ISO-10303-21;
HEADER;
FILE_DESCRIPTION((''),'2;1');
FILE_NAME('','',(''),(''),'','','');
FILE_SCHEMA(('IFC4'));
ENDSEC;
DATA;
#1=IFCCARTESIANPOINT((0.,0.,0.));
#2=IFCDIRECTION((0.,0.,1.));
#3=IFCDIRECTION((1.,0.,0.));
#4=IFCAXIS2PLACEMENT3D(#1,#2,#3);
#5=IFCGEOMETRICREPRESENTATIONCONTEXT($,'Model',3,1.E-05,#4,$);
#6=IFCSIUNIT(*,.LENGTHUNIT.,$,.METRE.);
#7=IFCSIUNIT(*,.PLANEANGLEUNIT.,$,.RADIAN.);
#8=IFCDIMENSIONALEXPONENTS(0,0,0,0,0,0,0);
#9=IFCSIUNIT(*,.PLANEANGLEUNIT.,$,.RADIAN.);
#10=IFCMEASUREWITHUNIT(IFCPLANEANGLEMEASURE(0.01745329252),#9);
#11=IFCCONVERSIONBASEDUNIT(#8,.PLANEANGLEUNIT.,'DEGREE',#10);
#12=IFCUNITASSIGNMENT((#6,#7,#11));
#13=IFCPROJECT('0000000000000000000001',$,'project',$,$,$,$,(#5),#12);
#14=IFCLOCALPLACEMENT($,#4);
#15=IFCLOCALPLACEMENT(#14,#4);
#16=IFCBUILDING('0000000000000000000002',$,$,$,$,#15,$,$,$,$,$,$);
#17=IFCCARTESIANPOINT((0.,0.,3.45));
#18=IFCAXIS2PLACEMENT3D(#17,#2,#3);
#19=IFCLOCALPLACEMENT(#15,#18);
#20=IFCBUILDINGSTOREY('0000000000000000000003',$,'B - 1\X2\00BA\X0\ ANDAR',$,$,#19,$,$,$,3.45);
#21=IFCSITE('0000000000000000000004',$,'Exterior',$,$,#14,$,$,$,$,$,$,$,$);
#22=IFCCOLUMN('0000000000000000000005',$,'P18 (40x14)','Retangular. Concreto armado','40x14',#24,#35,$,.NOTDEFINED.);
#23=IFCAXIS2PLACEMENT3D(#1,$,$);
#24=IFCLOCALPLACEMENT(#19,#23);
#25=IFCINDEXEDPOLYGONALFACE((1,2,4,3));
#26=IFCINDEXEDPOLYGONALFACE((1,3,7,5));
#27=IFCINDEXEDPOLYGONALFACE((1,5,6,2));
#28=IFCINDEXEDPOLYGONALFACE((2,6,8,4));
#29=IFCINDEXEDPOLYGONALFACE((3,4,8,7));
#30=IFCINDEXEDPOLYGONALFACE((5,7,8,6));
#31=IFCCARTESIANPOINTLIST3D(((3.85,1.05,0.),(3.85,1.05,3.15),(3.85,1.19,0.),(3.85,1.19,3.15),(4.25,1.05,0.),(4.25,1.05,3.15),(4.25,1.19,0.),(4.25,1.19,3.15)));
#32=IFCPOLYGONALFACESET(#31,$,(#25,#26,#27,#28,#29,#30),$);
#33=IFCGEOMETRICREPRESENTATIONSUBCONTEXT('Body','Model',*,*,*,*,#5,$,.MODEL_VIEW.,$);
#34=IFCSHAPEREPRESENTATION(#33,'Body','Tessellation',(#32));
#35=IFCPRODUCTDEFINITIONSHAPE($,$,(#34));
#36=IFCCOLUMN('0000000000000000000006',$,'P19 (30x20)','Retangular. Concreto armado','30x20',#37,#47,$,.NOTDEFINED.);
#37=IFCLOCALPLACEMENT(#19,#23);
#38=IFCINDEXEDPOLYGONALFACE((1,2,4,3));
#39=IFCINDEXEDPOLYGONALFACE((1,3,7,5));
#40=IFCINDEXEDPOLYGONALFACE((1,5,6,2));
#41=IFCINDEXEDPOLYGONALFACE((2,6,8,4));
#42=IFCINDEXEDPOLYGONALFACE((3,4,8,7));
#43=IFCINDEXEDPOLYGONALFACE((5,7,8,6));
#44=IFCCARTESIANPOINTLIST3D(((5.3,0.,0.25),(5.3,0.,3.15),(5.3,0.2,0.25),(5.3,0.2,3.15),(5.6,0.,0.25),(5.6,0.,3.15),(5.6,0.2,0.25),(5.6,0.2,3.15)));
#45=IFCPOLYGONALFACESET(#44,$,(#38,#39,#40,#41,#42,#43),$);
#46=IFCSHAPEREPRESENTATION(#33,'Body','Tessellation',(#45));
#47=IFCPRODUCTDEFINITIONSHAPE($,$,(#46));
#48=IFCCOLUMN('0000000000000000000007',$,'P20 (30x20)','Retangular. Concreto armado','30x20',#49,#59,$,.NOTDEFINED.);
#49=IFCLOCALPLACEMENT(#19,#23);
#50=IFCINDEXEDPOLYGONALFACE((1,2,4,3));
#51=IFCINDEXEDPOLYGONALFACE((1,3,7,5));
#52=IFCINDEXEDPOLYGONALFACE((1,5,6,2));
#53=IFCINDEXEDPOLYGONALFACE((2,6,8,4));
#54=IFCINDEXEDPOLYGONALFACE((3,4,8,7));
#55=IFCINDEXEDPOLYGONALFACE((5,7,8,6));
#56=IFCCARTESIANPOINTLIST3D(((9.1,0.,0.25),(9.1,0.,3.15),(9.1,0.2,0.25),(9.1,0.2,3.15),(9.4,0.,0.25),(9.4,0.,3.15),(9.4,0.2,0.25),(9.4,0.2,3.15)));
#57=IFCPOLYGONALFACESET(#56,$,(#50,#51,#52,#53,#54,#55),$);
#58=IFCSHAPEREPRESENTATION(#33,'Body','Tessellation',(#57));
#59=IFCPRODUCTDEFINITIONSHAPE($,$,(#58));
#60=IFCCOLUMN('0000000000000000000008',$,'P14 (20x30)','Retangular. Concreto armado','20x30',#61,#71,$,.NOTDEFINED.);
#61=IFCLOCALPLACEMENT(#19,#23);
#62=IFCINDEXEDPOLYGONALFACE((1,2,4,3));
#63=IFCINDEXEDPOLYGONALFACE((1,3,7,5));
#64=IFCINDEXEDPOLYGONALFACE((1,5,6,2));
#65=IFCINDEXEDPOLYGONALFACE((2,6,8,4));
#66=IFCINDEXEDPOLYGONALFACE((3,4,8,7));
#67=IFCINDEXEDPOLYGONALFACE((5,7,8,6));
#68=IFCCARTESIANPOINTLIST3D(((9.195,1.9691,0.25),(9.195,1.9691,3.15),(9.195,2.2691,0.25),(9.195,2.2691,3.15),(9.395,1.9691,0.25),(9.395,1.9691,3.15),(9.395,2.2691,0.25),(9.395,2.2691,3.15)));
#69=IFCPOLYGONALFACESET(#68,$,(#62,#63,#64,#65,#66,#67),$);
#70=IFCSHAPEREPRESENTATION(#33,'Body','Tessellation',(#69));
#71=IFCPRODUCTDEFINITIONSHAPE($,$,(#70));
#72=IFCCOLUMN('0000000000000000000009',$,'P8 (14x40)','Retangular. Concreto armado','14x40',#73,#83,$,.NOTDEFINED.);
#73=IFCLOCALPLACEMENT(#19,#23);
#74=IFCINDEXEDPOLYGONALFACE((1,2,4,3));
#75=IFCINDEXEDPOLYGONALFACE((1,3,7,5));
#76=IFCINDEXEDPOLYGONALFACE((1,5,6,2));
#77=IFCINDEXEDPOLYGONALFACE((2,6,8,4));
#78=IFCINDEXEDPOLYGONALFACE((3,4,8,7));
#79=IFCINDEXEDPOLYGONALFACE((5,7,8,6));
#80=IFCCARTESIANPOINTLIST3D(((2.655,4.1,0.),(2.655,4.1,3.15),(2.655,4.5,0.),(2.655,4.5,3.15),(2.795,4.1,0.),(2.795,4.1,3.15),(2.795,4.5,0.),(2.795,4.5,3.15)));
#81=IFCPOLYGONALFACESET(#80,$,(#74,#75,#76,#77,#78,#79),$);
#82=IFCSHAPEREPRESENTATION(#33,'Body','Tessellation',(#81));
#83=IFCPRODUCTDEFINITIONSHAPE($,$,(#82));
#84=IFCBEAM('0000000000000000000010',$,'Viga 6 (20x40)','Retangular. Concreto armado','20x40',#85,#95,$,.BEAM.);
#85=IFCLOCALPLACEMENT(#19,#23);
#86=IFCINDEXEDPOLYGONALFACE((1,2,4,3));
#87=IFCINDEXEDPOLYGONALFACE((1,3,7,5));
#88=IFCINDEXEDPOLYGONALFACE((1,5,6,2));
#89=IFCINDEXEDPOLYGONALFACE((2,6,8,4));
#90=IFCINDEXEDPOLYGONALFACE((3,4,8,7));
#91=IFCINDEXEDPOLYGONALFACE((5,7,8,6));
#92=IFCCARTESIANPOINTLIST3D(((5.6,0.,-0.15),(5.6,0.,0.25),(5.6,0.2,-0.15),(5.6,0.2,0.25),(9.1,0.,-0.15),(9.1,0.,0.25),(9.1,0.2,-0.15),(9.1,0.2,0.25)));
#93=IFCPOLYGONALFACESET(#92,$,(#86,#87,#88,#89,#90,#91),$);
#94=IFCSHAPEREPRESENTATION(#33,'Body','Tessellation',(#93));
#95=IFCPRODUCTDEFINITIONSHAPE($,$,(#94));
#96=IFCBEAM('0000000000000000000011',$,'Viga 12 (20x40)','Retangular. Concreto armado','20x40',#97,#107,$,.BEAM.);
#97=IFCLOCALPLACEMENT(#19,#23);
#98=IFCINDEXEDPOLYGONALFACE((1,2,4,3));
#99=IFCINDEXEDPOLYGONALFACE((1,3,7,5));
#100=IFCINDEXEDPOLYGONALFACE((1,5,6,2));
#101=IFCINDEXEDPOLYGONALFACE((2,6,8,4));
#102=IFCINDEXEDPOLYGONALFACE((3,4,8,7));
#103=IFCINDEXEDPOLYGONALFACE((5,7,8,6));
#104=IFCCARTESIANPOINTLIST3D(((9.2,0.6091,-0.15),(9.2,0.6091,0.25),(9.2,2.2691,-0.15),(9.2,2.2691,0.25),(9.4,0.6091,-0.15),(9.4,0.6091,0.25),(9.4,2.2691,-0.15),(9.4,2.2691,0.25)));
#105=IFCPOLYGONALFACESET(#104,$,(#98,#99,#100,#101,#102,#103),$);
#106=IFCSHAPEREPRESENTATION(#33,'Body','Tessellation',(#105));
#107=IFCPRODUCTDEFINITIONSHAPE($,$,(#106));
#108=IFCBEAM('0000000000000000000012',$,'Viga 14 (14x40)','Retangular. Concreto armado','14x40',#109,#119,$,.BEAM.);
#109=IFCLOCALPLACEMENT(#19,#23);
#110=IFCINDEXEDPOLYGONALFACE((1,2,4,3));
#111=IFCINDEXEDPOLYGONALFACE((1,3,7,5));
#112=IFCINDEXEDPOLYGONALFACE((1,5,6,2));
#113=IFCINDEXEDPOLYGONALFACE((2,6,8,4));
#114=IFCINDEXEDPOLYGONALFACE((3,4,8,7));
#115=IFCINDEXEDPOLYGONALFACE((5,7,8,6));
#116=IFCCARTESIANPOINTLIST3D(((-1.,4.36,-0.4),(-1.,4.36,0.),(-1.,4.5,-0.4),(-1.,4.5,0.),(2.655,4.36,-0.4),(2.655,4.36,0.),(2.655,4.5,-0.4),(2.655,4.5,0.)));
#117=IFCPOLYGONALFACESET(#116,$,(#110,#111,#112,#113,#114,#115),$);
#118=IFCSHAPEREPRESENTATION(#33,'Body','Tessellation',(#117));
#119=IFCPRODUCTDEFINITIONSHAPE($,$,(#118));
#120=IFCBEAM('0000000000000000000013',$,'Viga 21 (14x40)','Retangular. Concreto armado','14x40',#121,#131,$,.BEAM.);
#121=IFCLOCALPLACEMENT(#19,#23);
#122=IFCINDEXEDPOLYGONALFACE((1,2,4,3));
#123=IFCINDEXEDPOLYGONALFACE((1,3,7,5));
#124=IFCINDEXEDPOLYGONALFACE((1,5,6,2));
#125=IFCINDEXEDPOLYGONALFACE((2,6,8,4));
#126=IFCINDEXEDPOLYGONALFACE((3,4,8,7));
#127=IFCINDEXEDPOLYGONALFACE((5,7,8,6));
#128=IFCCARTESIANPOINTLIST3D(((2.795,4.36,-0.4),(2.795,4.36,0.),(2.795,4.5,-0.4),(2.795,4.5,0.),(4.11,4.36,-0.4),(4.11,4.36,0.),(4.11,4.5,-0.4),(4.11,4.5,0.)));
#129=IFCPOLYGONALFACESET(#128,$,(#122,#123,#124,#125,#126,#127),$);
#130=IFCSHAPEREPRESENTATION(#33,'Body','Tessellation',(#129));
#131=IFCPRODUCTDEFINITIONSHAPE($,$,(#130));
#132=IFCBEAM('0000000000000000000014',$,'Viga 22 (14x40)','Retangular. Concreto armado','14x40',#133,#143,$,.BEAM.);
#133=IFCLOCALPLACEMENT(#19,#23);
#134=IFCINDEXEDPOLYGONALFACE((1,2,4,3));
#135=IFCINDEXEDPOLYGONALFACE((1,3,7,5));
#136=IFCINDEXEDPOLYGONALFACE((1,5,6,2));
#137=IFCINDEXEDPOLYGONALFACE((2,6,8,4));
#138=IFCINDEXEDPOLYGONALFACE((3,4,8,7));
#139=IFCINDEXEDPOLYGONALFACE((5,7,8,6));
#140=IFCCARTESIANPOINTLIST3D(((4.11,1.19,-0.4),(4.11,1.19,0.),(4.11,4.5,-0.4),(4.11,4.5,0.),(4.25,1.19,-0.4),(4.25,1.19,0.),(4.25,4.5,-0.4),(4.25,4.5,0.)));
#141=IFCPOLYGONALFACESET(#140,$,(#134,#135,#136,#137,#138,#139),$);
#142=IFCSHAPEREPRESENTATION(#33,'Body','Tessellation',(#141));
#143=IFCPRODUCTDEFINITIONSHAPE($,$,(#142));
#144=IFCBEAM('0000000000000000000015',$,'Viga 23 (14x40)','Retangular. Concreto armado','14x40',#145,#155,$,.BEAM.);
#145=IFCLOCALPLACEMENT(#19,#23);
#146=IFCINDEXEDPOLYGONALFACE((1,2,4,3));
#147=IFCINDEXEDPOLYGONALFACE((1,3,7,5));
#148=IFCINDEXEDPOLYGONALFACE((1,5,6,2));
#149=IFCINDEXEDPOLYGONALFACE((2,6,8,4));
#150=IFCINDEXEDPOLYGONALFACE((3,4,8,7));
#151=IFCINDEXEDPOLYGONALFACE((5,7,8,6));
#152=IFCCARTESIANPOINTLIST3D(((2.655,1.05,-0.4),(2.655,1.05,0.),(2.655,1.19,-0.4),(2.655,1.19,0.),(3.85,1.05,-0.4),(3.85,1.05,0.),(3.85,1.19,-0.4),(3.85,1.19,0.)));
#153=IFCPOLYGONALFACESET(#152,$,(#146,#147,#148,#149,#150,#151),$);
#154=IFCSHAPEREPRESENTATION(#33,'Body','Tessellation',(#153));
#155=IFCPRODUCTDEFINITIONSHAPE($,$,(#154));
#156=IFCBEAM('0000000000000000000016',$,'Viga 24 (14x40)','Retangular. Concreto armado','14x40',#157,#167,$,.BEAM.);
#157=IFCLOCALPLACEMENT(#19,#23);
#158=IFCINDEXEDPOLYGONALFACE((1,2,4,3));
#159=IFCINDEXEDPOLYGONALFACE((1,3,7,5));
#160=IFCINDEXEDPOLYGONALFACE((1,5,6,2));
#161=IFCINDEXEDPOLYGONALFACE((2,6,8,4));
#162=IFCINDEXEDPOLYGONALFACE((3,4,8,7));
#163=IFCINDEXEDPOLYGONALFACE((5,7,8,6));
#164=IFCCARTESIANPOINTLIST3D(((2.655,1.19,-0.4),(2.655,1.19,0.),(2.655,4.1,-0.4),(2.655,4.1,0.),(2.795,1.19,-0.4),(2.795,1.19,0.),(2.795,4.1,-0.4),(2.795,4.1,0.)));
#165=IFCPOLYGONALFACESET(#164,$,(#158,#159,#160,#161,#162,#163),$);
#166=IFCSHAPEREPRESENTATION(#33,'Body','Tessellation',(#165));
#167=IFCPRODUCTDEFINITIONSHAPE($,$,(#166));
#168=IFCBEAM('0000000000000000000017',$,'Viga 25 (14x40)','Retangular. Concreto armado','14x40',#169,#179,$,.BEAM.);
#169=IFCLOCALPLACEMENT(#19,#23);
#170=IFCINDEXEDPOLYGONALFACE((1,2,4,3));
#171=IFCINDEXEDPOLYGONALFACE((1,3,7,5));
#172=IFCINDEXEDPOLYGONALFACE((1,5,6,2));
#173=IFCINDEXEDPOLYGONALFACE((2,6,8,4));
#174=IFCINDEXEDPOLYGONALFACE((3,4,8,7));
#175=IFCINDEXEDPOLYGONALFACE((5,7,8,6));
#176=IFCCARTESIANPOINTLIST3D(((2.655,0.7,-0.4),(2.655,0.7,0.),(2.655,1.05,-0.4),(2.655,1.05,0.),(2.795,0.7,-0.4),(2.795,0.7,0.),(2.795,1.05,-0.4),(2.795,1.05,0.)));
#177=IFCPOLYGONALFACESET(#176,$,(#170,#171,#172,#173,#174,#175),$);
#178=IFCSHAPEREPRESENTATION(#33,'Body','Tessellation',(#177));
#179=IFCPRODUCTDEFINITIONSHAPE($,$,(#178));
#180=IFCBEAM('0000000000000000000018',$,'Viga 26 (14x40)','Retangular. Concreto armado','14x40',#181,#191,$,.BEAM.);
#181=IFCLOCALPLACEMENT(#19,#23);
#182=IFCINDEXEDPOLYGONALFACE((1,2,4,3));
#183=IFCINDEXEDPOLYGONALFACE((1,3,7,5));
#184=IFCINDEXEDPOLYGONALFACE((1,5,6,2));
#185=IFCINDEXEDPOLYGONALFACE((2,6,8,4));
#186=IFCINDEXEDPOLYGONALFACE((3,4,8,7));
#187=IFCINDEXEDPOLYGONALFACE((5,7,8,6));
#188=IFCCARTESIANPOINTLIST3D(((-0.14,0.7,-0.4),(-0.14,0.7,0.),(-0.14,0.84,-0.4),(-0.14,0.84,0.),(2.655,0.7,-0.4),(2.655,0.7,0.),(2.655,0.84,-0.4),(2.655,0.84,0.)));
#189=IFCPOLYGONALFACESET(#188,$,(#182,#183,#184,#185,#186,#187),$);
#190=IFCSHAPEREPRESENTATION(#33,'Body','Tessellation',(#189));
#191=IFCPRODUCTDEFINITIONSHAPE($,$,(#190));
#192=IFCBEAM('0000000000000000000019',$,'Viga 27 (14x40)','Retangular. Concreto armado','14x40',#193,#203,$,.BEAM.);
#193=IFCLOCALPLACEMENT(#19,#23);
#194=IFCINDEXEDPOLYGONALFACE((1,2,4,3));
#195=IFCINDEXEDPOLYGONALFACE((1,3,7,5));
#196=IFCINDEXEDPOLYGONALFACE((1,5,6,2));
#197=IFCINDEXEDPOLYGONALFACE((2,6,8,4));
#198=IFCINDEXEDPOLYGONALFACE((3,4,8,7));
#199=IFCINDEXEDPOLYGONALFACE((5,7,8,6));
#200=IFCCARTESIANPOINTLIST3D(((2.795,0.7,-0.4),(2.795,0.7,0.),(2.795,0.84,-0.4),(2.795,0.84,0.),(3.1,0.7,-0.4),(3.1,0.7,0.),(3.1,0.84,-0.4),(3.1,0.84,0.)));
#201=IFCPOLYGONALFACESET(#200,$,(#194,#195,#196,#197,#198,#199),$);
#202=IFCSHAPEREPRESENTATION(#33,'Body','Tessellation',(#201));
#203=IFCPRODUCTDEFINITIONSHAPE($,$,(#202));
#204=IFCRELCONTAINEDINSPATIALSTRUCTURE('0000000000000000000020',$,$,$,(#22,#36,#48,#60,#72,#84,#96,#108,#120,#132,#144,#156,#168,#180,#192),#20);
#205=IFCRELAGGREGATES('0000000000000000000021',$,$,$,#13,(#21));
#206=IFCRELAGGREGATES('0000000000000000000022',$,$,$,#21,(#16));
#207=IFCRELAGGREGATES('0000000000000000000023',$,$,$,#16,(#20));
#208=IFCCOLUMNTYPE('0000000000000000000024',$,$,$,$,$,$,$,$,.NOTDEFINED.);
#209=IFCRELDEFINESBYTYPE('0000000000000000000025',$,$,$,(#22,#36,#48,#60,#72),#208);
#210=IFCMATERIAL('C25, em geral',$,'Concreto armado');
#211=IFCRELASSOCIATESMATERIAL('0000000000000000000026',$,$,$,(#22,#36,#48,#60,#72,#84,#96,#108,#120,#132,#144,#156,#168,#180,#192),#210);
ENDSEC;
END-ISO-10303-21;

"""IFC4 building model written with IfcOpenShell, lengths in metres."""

from ifc_helpers import new_model, entity, si_unit, converted_unit, frame, frame_2d, origin_with_axes, origin_2d_with_axis, place, context, subcontext, project, spatial, rectangle, extrude, material, type_object, element, save


model = new_model("IFC4")

# Units and contexts
model_context = context("Model", 3, precision=1e-05, world=origin_with_axes())
body_context = subcontext(model_context, "Body", "Model", "MODEL_VIEW")
ifc_project = project(units=[si_unit("LENGTHUNIT", "METRE"), si_unit("PLANEANGLEUNIT", "RADIAN"), converted_unit("PLANEANGLEUNIT", "DEGREE", entity("IfcPlaneAngleMeasure", 0.01745329252), si_unit("PLANEANGLEUNIT", "RADIAN"), dimensions=[0, 0, 0, 0, 0, 0, 0])], contexts=[model_context])

# Site, building, storey
site_placement = place(None, origin_with_axes())
site = spatial("IfcSite", under=ifc_project, at=site_placement, Name="Exterior")
building_placement = place(site_placement, origin_with_axes())
building = spatial("IfcBuilding", under=site, at=building_placement)
storey_placement = place(building_placement, frame((0.0, 0.0, 3.45), z_axis=(0.0, 0.0, 1.0), x_axis=(1.0, 0.0, 0.0)))
storey = spatial("IfcBuildingStorey", under=building, at=storey_placement, Name="B - 1º ANDAR", Elevation=3.45)

# Columns
ifc_material = material(Name="C25, em geral", Category="Concreto armado")
column_type = type_object("IfcColumnType", PredefinedType="NOTDEFINED")
column_1_placement = place(storey_placement, frame((4.25, 1.12, 0.0), z_axis=(0.0, 0.0, 1.0), x_axis=(1.0, 0.0, 0.0)))
element("IfcColumn", 1, at=column_1_placement, inside=storey, type_object=column_type, material=ifc_material, Name="P18 (40x14)", Description="Retangular. Concreto armado", ObjectType="40x14", PredefinedType="NOTDEFINED", context=body_context, shape_type="SweptSolid", body=[
    extrude(rectangle(XDim=0.4, YDim=0.14, at=frame_2d((-0.2, 0.0), x_axis=(1.0, 0.0))), origin_with_axes(), (0.0, 0.0, 1.0), 3.15),
])
for number, where, z_axis, x_axis, name in (
    (2, (5.45, 0.1, 0.25), (0.0, 0.0, 1.0), (1.0, 0.0, 0.0), "P19 (30x20)"),
    (3, (9.25, 0.1, 0.25), (0.0, 0.0, 1.0), (1.0, 0.0, 0.0), "P20 (30x20)"),
):
    element("IfcColumn", number, at=place(storey_placement, frame(where, z_axis=z_axis, x_axis=x_axis)), inside=storey, type_object=column_type, material=ifc_material, Name=name, Description="Retangular. Concreto armado", ObjectType="30x20", PredefinedType="NOTDEFINED", context=body_context, shape_type="SweptSolid", body=[
        extrude(rectangle(XDim=0.3, YDim=0.2, at=origin_2d_with_axis()), origin_with_axes(), (0.0, 0.0, 1.0), 2.9),
    ])
column_2_placement = place(storey_placement, frame((9.295, 2.1191, 0.25), z_axis=(0.0, 0.0, 1.0), x_axis=(1.0, 0.0, 0.0)))
element("IfcColumn", 4, at=column_2_placement, inside=storey, type_object=column_type, material=ifc_material, Name="P14 (20x30)", Description="Retangular. Concreto armado", ObjectType="20x30", PredefinedType="NOTDEFINED", context=body_context, shape_type="SweptSolid", body=[
    extrude(rectangle(XDim=0.2, YDim=0.3, at=origin_2d_with_axis()), origin_with_axes(), (0.0, 0.0, 1.0), 2.9),
])
column_3_placement = place(storey_placement, frame((2.725, 4.5, 0.0), z_axis=(0.0, 0.0, 1.0), x_axis=(1.0, 0.0, 0.0)))
element("IfcColumn", 5, at=column_3_placement, inside=storey, type_object=column_type, material=ifc_material, Name="P8 (14x40)", Description="Retangular. Concreto armado", ObjectType="14x40", PredefinedType="NOTDEFINED", context=body_context, shape_type="SweptSolid", body=[
    extrude(rectangle(XDim=0.14, YDim=0.4, at=frame_2d((0.0, -0.2), x_axis=(1.0, 0.0))), origin_with_axes(), (0.0, 0.0, 1.0), 3.15),
])

# Beams
beam_1_placement = place(storey_placement, frame((9.1, 0.1, 0.25), z_axis=(-1.0, 0.0, 0.0), x_axis=(0.0, -1.0, 0.0)))
element("IfcBeam", 6, at=beam_1_placement, inside=storey, material=ifc_material, Name="Viga 6 (20x40)", Description="Retangular. Concreto armado", ObjectType="20x40", PredefinedType="BEAM", context=body_context, shape_type="SweptSolid", body=[
    extrude(rectangle(XDim=0.2, YDim=0.4, at=frame_2d((0.0, -0.2), x_axis=(1.0, 0.0))), origin_with_axes(), (0.0, 0.0, 1.0), 3.5),
])
beam_2_placement = place(storey_placement, frame((9.3, 2.2691, 0.25), z_axis=(0.0, -1.0, 0.0), x_axis=(1.0, 0.0, 0.0)))
element("IfcBeam", 7, at=beam_2_placement, inside=storey, material=ifc_material, Name="Viga 12 (20x40)", Description="Retangular. Concreto armado", ObjectType="20x40", PredefinedType="BEAM", context=body_context, shape_type="SweptSolid", body=[
    extrude(rectangle(XDim=0.2, YDim=0.4, at=frame_2d((0.0, -0.2), x_axis=(1.0, 0.0))), origin_with_axes(), (0.0, 0.0, 1.0), 1.66),
])
beam_3_placement = place(storey_placement, frame((2.655, 4.43, 0.0), z_axis=(-1.0, 0.0, 0.0), x_axis=(0.0, -1.0, 0.0)))
element("IfcBeam", 8, at=beam_3_placement, inside=storey, material=ifc_material, Name="Viga 14 (14x40)", Description="Retangular. Concreto armado", ObjectType="14x40", PredefinedType="BEAM", context=body_context, shape_type="SweptSolid", body=[
    extrude(rectangle(XDim=0.14, YDim=0.4, at=frame_2d((0.0, -0.2), x_axis=(1.0, 0.0))), origin_with_axes(), (0.0, 0.0, 1.0), 3.655),
])
beam_4_placement = place(storey_placement, frame((2.795, 4.43, 0.0), z_axis=(1.0, 0.0, 0.0), x_axis=(0.0, 1.0, 0.0)))
element("IfcBeam", 9, at=beam_4_placement, inside=storey, material=ifc_material, Name="Viga 21 (14x40)", Description="Retangular. Concreto armado", ObjectType="14x40", PredefinedType="BEAM", context=body_context, shape_type="SweptSolid", body=[
    extrude(rectangle(XDim=0.14, YDim=0.4, at=frame_2d((0.0, -0.2), x_axis=(1.0, 0.0))), origin_with_axes(), (0.0, 0.0, 1.0), 1.315),
])
beam_5_placement = place(storey_placement, frame((4.18, 1.19, 0.0), z_axis=(0.0, 1.0, 0.0), x_axis=(-1.0, 0.0, 0.0)))
element("IfcBeam", 10, at=beam_5_placement, inside=storey, material=ifc_material, Name="Viga 22 (14x40)", Description="Retangular. Concreto armado", ObjectType="14x40", PredefinedType="BEAM", context=body_context, shape_type="SweptSolid", body=[
    extrude(rectangle(XDim=0.14, YDim=0.4, at=frame_2d((0.0, -0.2), x_axis=(1.0, 0.0))), origin_with_axes(), (0.0, 0.0, 1.0), 3.31),
])
beam_6_placement = place(storey_placement, frame((3.85, 1.12, 0.0), z_axis=(-1.0, 0.0, 0.0), x_axis=(0.0, -1.0, 0.0)))
element("IfcBeam", 11, at=beam_6_placement, inside=storey, material=ifc_material, Name="Viga 23 (14x40)", Description="Retangular. Concreto armado", ObjectType="14x40", PredefinedType="BEAM", context=body_context, shape_type="SweptSolid", body=[
    extrude(rectangle(XDim=0.14, YDim=0.4, at=frame_2d((0.0, -0.2), x_axis=(1.0, 0.0))), origin_with_axes(), (0.0, 0.0, 1.0), 1.195),
])
beam_7_placement = place(storey_placement, frame((2.725, 4.1, 0.0), z_axis=(0.0, -1.0, 0.0), x_axis=(1.0, 0.0, 0.0)))
element("IfcBeam", 12, at=beam_7_placement, inside=storey, material=ifc_material, Name="Viga 24 (14x40)", Description="Retangular. Concreto armado", ObjectType="14x40", PredefinedType="BEAM", context=body_context, shape_type="SweptSolid", body=[
    extrude(rectangle(XDim=0.14, YDim=0.4, at=frame_2d((0.0, -0.2), x_axis=(1.0, 0.0))), origin_with_axes(), (0.0, 0.0, 1.0), 2.91),
])
beam_8_placement = place(storey_placement, frame((2.725, 1.05, 0.0), z_axis=(0.0, -1.0, 0.0), x_axis=(1.0, 0.0, 0.0)))
element("IfcBeam", 13, at=beam_8_placement, inside=storey, material=ifc_material, Name="Viga 25 (14x40)", Description="Retangular. Concreto armado", ObjectType="14x40", PredefinedType="BEAM", context=body_context, shape_type="SweptSolid", body=[
    extrude(rectangle(XDim=0.14, YDim=0.4, at=frame_2d((0.0, -0.2), x_axis=(1.0, 0.0))), origin_with_axes(), (0.0, 0.0, 1.0), 0.35),
])
beam_9_placement = place(storey_placement, frame((2.655, 0.77, 0.0), z_axis=(-1.0, 0.0, 0.0), x_axis=(0.0, -1.0, 0.0)))
element("IfcBeam", 14, at=beam_9_placement, inside=storey, material=ifc_material, Name="Viga 26 (14x40)", Description="Retangular. Concreto armado", ObjectType="14x40", PredefinedType="BEAM", context=body_context, shape_type="SweptSolid", body=[
    extrude(rectangle(XDim=0.14, YDim=0.4, at=frame_2d((0.0, -0.2), x_axis=(1.0, 0.0))), origin_with_axes(), (0.0, 0.0, 1.0), 2.795),
])
beam_10_placement = place(storey_placement, frame((3.1, 0.77, 0.0), z_axis=(-1.0, 0.0, 0.0), x_axis=(0.0, -1.0, 0.0)))
element("IfcBeam", 15, at=beam_10_placement, inside=storey, material=ifc_material, Name="Viga 27 (14x40)", Description="Retangular. Concreto armado", ObjectType="14x40", PredefinedType="BEAM", context=body_context, shape_type="SweptSolid", body=[
    extrude(rectangle(XDim=0.14, YDim=0.4, at=frame_2d((0.0, -0.2), x_axis=(1.0, 0.0))), origin_with_axes(), (0.0, 0.0, 1.0), 0.305),
])

save(model, "model.ifc")
